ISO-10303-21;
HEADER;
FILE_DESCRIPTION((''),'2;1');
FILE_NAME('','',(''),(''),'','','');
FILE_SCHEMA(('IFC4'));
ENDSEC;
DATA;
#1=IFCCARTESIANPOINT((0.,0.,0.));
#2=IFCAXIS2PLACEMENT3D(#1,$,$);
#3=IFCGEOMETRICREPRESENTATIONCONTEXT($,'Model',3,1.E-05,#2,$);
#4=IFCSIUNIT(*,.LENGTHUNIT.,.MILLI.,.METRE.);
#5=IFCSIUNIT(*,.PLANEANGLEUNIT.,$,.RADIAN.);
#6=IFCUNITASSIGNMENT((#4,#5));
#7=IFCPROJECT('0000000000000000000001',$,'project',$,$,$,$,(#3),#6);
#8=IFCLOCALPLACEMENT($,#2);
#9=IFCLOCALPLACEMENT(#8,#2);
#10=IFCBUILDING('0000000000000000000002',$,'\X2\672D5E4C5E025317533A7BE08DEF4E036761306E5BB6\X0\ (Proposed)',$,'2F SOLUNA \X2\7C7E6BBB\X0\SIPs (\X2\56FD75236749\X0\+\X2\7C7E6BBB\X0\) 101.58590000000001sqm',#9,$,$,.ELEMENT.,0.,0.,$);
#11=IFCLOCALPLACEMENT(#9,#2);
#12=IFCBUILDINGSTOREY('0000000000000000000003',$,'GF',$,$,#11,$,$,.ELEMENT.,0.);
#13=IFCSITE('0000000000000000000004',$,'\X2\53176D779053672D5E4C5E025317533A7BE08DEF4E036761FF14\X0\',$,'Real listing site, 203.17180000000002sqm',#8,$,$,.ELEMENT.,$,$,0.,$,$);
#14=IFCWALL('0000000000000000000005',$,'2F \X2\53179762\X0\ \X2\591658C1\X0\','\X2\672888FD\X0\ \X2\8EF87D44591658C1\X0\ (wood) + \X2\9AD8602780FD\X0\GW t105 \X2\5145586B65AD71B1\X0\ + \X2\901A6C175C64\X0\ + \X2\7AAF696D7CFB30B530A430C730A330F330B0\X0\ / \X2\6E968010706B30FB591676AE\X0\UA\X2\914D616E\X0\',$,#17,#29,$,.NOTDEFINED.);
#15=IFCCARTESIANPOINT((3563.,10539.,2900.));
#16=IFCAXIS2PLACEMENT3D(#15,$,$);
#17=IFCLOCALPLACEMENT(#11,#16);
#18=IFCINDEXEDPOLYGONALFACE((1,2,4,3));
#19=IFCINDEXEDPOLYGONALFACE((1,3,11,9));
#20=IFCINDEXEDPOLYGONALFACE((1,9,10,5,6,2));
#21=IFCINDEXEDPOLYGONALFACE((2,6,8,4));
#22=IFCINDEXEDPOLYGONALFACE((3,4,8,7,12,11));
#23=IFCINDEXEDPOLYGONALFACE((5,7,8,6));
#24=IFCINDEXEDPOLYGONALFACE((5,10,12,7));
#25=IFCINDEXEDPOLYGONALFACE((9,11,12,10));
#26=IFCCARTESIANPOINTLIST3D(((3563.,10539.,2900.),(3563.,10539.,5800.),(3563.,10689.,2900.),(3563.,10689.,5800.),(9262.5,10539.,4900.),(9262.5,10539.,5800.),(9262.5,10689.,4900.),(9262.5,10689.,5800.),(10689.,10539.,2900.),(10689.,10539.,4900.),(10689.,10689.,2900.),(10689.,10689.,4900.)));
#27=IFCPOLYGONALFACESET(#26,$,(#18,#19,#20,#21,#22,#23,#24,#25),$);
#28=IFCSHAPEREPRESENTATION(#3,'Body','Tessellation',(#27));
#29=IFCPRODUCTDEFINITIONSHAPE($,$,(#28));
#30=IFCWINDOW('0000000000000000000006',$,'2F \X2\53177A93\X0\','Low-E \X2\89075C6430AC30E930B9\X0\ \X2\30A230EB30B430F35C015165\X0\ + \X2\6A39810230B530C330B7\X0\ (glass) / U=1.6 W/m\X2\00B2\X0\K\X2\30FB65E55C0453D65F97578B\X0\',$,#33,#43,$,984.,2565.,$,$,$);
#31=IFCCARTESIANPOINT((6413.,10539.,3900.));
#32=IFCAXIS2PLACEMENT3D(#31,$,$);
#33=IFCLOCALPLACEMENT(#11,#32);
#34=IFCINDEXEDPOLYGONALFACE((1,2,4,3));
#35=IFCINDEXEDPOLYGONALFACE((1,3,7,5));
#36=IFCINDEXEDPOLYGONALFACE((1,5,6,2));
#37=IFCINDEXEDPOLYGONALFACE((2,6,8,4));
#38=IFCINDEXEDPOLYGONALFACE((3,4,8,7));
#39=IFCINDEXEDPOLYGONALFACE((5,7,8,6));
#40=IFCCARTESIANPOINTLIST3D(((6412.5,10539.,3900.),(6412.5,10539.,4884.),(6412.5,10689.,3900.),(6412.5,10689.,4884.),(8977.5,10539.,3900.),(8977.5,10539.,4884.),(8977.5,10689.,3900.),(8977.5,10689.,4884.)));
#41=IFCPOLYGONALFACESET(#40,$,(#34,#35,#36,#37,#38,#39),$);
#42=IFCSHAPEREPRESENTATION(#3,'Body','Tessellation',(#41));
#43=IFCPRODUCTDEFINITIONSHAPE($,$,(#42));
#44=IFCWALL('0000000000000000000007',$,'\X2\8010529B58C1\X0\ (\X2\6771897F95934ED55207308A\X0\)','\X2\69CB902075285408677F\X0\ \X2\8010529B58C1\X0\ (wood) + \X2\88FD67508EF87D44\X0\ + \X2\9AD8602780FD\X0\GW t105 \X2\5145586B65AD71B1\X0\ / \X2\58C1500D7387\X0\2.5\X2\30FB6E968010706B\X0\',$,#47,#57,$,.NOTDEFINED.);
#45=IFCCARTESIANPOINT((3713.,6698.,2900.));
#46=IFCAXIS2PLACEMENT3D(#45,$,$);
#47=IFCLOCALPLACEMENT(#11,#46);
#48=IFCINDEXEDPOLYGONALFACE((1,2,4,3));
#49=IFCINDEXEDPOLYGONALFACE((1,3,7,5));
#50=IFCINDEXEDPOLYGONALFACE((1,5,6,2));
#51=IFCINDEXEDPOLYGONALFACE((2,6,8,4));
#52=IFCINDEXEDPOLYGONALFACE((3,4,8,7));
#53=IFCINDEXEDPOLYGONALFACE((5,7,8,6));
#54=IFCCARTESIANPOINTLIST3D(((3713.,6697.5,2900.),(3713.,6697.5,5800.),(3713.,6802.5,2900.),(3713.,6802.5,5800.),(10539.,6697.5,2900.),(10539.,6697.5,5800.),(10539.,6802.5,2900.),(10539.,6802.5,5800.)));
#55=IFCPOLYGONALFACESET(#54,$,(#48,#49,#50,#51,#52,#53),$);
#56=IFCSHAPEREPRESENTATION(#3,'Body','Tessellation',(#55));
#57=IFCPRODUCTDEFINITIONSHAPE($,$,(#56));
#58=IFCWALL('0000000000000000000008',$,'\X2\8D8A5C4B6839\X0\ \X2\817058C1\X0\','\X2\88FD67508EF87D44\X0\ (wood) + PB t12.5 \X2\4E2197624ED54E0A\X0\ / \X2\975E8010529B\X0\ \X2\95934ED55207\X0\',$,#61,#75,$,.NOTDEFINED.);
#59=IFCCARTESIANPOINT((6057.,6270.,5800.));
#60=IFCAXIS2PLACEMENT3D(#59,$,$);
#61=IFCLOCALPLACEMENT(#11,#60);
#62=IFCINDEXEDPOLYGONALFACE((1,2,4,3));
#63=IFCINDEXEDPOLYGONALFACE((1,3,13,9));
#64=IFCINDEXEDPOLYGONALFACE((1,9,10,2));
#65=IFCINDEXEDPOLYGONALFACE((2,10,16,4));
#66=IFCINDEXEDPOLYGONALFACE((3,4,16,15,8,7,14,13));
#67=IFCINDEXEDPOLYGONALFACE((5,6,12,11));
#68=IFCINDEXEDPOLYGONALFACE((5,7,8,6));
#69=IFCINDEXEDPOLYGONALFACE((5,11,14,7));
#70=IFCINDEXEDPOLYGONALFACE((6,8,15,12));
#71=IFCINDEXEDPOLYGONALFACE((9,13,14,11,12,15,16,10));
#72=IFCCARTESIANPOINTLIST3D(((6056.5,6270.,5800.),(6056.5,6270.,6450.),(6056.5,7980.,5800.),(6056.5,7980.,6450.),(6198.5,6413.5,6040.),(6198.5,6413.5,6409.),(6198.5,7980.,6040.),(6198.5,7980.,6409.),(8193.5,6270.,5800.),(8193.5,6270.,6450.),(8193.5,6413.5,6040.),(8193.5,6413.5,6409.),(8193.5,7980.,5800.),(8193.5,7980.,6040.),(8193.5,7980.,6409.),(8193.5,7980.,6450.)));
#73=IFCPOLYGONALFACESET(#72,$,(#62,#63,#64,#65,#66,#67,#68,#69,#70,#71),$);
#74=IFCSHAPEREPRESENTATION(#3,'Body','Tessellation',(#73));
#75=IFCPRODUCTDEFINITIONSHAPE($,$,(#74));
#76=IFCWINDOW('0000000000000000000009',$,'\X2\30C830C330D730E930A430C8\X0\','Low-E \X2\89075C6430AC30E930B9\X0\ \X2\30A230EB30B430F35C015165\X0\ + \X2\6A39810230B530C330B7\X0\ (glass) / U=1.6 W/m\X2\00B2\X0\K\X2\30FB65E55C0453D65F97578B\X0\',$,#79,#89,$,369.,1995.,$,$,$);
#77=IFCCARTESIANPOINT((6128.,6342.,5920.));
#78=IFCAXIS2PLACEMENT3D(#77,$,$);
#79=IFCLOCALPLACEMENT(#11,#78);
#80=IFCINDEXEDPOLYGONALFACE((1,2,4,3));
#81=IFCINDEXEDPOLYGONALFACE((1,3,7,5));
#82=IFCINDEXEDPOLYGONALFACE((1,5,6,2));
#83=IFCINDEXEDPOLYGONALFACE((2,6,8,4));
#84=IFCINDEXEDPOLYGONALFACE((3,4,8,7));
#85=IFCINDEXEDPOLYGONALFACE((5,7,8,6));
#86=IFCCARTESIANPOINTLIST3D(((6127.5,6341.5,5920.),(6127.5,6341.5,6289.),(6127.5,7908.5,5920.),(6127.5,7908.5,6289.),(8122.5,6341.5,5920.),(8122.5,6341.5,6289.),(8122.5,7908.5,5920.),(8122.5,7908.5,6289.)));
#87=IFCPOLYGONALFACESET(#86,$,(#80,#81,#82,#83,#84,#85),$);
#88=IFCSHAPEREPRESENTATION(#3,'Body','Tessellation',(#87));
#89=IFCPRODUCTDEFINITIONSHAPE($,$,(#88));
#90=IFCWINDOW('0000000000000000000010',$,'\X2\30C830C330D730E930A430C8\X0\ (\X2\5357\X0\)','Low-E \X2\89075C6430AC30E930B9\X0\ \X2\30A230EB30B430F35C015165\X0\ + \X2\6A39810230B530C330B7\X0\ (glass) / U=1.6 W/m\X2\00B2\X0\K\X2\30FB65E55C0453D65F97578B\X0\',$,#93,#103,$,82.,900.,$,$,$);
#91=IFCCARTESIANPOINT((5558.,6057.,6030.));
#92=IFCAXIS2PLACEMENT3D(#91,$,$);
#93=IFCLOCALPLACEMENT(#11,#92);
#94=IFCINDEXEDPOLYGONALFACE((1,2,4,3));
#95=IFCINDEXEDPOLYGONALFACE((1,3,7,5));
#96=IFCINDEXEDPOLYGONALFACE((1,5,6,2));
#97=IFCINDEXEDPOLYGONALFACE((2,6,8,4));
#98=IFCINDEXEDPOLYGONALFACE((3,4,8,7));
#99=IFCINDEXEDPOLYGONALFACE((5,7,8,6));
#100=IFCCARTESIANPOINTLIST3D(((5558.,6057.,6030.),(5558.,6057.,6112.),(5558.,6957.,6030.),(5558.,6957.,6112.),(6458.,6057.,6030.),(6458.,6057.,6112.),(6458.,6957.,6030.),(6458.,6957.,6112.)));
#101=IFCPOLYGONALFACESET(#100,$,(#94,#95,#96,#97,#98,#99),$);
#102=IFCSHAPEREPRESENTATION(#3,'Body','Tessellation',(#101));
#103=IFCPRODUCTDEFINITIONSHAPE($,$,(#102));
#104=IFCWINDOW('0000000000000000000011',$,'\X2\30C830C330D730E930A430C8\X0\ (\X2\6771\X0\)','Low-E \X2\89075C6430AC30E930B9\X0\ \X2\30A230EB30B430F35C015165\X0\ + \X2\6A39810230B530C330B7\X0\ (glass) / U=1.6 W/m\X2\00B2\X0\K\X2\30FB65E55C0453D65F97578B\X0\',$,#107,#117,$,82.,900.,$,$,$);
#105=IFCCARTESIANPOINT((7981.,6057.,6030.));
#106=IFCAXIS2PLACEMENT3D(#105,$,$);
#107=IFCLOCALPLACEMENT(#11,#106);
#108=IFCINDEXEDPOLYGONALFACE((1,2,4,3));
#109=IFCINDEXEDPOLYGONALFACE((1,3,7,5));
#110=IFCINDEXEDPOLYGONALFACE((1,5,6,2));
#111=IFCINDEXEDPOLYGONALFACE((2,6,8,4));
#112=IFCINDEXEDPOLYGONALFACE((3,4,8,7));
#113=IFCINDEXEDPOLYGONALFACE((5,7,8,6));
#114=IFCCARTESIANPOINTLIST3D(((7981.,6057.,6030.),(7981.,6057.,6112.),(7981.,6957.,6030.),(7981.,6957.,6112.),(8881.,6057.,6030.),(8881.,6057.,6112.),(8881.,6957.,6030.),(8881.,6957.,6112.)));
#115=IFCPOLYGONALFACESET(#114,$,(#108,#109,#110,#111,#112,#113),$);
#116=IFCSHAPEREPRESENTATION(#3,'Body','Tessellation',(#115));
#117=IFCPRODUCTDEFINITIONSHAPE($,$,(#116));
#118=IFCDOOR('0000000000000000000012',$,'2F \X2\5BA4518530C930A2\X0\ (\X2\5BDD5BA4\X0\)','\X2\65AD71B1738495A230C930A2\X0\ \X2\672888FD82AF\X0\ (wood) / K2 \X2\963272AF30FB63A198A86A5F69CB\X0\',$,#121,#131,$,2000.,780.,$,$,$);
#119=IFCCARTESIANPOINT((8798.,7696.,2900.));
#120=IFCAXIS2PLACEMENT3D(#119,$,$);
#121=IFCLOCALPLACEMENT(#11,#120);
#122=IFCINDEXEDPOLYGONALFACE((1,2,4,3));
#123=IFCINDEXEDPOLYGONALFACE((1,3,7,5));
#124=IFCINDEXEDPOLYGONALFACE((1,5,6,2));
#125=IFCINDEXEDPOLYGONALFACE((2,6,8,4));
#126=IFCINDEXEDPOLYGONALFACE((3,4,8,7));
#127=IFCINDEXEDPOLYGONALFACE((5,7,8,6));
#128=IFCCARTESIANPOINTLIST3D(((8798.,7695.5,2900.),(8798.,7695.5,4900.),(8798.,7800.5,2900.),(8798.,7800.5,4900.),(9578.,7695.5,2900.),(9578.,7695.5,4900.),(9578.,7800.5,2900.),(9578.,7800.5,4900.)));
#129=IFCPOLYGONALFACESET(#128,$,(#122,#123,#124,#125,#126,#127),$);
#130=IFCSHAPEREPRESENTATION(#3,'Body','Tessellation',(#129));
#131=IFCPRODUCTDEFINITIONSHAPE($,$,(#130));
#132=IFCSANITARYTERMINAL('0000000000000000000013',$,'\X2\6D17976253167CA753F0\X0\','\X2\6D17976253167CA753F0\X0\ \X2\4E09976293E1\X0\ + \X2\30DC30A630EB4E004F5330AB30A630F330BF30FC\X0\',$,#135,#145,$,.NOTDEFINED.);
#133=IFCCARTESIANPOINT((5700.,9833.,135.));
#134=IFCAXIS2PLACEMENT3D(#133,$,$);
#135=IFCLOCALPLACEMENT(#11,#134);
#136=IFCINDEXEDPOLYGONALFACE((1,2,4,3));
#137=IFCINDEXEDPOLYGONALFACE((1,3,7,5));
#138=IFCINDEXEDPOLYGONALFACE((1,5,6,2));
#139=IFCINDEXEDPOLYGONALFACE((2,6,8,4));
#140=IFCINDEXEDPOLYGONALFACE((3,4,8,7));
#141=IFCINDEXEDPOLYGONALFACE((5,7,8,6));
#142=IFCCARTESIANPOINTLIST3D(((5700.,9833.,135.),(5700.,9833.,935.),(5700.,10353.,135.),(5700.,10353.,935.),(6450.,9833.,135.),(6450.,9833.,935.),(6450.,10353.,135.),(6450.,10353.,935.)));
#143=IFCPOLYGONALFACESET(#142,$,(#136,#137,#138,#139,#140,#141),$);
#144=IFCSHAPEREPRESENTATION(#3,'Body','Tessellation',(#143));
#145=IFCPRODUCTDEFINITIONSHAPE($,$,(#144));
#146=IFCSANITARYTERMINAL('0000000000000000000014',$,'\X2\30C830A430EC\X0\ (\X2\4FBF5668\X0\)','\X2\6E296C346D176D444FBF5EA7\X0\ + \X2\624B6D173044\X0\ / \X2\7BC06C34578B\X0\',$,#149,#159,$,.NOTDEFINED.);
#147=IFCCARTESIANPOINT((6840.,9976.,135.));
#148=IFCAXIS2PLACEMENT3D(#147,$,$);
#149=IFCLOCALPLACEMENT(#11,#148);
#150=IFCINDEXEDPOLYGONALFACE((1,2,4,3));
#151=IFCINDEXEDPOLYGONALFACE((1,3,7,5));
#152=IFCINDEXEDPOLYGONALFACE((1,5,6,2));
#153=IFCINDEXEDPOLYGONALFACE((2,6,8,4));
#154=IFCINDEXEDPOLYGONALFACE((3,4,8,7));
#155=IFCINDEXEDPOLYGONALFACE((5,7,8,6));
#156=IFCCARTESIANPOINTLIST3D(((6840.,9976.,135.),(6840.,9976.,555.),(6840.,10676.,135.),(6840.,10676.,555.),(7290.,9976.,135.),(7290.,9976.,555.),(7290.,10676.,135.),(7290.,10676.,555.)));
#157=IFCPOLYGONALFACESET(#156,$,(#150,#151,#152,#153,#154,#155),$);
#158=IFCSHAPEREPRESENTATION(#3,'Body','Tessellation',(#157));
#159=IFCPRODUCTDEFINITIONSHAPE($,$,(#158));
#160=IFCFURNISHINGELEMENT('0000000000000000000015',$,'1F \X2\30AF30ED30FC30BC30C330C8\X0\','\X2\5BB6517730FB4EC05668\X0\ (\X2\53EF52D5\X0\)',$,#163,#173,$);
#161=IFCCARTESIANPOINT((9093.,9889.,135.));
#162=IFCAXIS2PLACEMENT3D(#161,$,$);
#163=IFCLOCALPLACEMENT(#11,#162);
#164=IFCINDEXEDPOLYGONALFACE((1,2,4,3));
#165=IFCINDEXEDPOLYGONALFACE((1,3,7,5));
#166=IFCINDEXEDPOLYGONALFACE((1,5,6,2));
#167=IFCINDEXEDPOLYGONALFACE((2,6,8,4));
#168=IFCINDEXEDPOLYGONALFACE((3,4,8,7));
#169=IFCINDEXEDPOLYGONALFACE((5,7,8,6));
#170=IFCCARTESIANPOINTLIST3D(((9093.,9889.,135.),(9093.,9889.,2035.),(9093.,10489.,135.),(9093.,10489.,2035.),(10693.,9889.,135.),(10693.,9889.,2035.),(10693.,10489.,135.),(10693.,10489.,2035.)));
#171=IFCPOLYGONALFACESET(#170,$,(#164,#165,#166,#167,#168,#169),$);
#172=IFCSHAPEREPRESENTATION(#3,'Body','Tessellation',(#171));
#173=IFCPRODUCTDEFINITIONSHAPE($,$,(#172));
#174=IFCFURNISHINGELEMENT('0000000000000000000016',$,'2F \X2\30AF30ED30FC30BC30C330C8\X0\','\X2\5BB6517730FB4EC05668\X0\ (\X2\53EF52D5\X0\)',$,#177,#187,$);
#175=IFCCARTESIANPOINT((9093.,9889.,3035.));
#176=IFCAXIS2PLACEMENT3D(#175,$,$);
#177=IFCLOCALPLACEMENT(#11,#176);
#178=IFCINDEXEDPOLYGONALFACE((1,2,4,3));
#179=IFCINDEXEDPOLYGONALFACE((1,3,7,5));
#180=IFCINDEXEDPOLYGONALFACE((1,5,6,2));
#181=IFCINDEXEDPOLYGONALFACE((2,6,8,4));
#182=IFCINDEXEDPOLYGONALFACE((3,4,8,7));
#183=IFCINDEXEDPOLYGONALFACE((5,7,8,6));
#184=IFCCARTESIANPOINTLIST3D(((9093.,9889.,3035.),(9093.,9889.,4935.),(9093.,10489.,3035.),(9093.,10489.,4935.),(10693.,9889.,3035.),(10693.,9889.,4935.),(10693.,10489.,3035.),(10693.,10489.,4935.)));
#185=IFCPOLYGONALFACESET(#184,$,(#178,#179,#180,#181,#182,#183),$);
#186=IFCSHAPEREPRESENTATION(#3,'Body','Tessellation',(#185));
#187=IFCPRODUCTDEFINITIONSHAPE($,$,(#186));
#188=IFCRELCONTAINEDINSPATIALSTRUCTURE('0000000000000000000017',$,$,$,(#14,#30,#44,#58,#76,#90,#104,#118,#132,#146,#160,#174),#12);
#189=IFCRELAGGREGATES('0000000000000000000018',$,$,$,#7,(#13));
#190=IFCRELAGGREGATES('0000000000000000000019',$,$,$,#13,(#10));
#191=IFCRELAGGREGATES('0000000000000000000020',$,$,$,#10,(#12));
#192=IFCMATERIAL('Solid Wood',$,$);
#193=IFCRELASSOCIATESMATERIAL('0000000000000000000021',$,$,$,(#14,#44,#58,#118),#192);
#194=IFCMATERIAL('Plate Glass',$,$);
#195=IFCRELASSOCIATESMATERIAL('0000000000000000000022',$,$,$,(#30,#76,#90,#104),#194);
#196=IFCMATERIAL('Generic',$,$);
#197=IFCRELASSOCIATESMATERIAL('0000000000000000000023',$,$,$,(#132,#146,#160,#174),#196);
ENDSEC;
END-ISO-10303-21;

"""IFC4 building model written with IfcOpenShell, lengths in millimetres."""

from ifc_helpers import new_model, si_unit, frame, frame_2d, origin, place, context, project, spatial, rectangle, extrude, material, element, fill, save


model = new_model("IFC4")

# Units and contexts
model_context = context("Model", 3, precision=1e-05, world=origin())
ifc_project = project(units=[si_unit("LENGTHUNIT", "METRE", prefix="MILLI"), si_unit("PLANEANGLEUNIT", "RADIAN")], contexts=[model_context])

# Site, building, storey
site_placement = place(None, origin())
site = spatial("IfcSite", under=ifc_project, at=site_placement, Name="北海道札幌市北区篠路七条４", ObjectType="Real listing site, 203.17180000000002sqm", CompositionType="ELEMENT", RefElevation=0.0)
building_placement = place(site_placement, origin())
building = spatial("IfcBuilding", under=site, at=building_placement, Name="札幌市北区篠路七条の家 (Proposed)", ObjectType="2F SOLUNA 籾殻SIPs (国産杉+籾殻) 101.58590000000001sqm", CompositionType="ELEMENT", ElevationOfRefHeight=0.0, ElevationOfTerrain=0.0)
storey_placement = place(building_placement, origin())
storey = spatial("IfcBuildingStorey", under=building, at=storey_placement, Name="GF", CompositionType="ELEMENT", Elevation=0.0)

# Wall, opening, window
ifc_material_1 = material(Name="Solid Wood")
wall_1_placement = place(storey_placement, frame((3563.0, 10539.0, 2900.0)))
wall_1 = element("IfcWall", 1, at=wall_1_placement, inside=storey, material=ifc_material_1, Name="2F 北面 外壁", Description="木製 軸組外壁 (wood) + 高性能GW t105 充填断熱 + 通気層 + 窯業系サイディング / 準耐火・外皮UA配慮", PredefinedType="NOTDEFINED", context=model_context, shape_type="SweptSolid", body=[
    extrude(rectangle(XDim=7126.0, YDim=150.0, at=frame_2d((3563.0, 75.0))), frame((3563.0, 10539.0, 2900.0)), (0.0, 0.0, 1.0), 2900.0),
])
opening_1_placement = place(storey_placement, frame((6413.0, 10539.0, 3900.0)))
opening_1 = element("IfcOpeningElement", 2, at=opening_1_placement, cuts=wall_1, PredefinedType="NOTDEFINED", context=model_context, shape_type="SweptSolid", body=[
    extrude(rectangle(XDim=2565.0, YDim=150.0, at=frame_2d((1282.0, 75.0))), frame((6413.0, 10539.0, 3900.0)), (0.0, 0.0, 1.0), 984.0),
])
ifc_material_2 = material(Name="Plate Glass")
window_1_placement = place(storey_placement, frame((6413.0, 10539.0, 3900.0)))
window_1 = element("IfcWindow", 3, at=window_1_placement, inside=storey, material=ifc_material_2, Name="2F 北窓", Description="Low-E 複層ガラス アルゴン封入 + 樹脂サッシ (glass) / U=1.6 W/m²K・日射取得型", OverallHeight=984.0, OverallWidth=2565.0, context=model_context, shape_type="SweptSolid", body=[
    extrude(rectangle(XDim=2565.0, YDim=150.0, at=frame_2d((1282.0, 75.0))), frame((6413.0, 10539.0, 3900.0)), (0.0, 0.0, 1.0), 984.0),
])
fill(opening_1, window_1)

# Wall
wall_2_placement = place(storey_placement, frame((3713.0, 6698.0, 2900.0)))
element("IfcWall", 4, at=wall_2_placement, inside=storey, material=ifc_material_1, Name="耐力壁 (東西間仕切り)", Description="構造用合板 耐力壁 (wood) + 製材軸組 + 高性能GW t105 充填断熱 / 壁倍率2.5・準耐火", PredefinedType="NOTDEFINED", context=model_context, shape_type="SweptSolid", body=[
    extrude(rectangle(XDim=6826.0, YDim=105.0, at=frame_2d((3413.0, 52.0))), frame((3713.0, 6698.0, 2900.0)), (0.0, 0.0, 1.0), 2900.0),
])

# Wall, openings, windows
wall_3_placement = place(storey_placement, frame((6057.0, 6270.0, 5800.0)))
wall_3 = element("IfcWall", 5, at=wall_3_placement, inside=storey, material=ifc_material_1, Name="越屋根 腰壁", Description="製材軸組 (wood) + PB t12.5 両面仕上 / 非耐力 間仕切", PredefinedType="NOTDEFINED", context=model_context, shape_type="SweptSolid", body=[
    extrude(rectangle(XDim=2137.0, YDim=1710.0, at=frame_2d((1068.0, 855.0))), frame((6057.0, 6270.0, 5800.0)), (0.0, 0.0, 1.0), 650.0),
])
opening_2_placement = place(storey_placement, frame((6128.0, 6342.0, 5920.0)))
opening_2 = element("IfcOpeningElement", 6, at=opening_2_placement, cuts=wall_3, PredefinedType="NOTDEFINED", context=model_context, shape_type="SweptSolid", body=[
    extrude(rectangle(XDim=1995.0, YDim=1567.0, at=frame_2d((997.0, 783.0))), frame((6128.0, 6342.0, 5920.0)), (0.0, 0.0, 1.0), 369.0),
])
opening_3_placement = place(storey_placement, frame((5558.0, 6057.0, 6030.0)))
opening_3 = element("IfcOpeningElement", 7, at=opening_3_placement, cuts=wall_3, PredefinedType="NOTDEFINED", context=model_context, shape_type="SweptSolid", body=[
    extrude(rectangle(XDim=900.0, YDim=900.0, at=frame_2d((450.0, 450.0))), frame((5558.0, 6057.0, 6030.0)), (0.0, 0.0, 1.0), 82.0),
])
opening_4_placement = place(storey_placement, frame((7981.0, 6057.0, 6030.0)))
opening_4 = element("IfcOpeningElement", 8, at=opening_4_placement, cuts=wall_3, PredefinedType="NOTDEFINED", context=model_context, shape_type="SweptSolid", body=[
    extrude(rectangle(XDim=900.0, YDim=900.0, at=frame_2d((450.0, 450.0))), frame((7981.0, 6057.0, 6030.0)), (0.0, 0.0, 1.0), 82.0),
])
window_2_placement = place(storey_placement, frame((6128.0, 6342.0, 5920.0)))
window_2 = element("IfcWindow", 9, at=window_2_placement, inside=storey, material=ifc_material_2, Name="トップライト", Description="Low-E 複層ガラス アルゴン封入 + 樹脂サッシ (glass) / U=1.6 W/m²K・日射取得型", OverallHeight=369.0, OverallWidth=1995.0, context=model_context, shape_type="SweptSolid", body=[
    extrude(rectangle(XDim=1995.0, YDim=1567.0, at=frame_2d((997.0, 783.0))), frame((6128.0, 6342.0, 5920.0)), (0.0, 0.0, 1.0), 369.0),
])
fill(opening_2, window_2)
window_3_placement = place(storey_placement, frame((5558.0, 6057.0, 6030.0)))
window_3 = element("IfcWindow", 10, at=window_3_placement, inside=storey, material=ifc_material_2, Name="トップライト (南)", Description="Low-E 複層ガラス アルゴン封入 + 樹脂サッシ (glass) / U=1.6 W/m²K・日射取得型", OverallHeight=82.0, OverallWidth=900.0, context=model_context, shape_type="SweptSolid", body=[
    extrude(rectangle(XDim=900.0, YDim=900.0, at=frame_2d((450.0, 450.0))), frame((5558.0, 6057.0, 6030.0)), (0.0, 0.0, 1.0), 82.0),
])
fill(opening_3, window_3)
window_4_placement = place(storey_placement, frame((7981.0, 6057.0, 6030.0)))
window_4 = element("IfcWindow", 11, at=window_4_placement, inside=storey, material=ifc_material_2, Name="トップライト (東)", Description="Low-E 複層ガラス アルゴン封入 + 樹脂サッシ (glass) / U=1.6 W/m²K・日射取得型", OverallHeight=82.0, OverallWidth=900.0, context=model_context, shape_type="SweptSolid", body=[
    extrude(rectangle(XDim=900.0, YDim=900.0, at=frame_2d((450.0, 450.0))), frame((7981.0, 6057.0, 6030.0)), (0.0, 0.0, 1.0), 82.0),
])
fill(opening_4, window_4)

# Door
door_placement = place(storey_placement, frame((8798.0, 7696.0, 2900.0)))
element("IfcDoor", 12, at=door_placement, inside=storey, material=ifc_material_1, Name="2F 室内ドア (寝室)", Description="断熱玄関ドア 木製芯 (wood) / K2 防犯・採風機構", OverallHeight=2000.0, OverallWidth=780.0, context=model_context, shape_type="SweptSolid", body=[
    extrude(rectangle(XDim=780.0, YDim=105.0, at=frame_2d((390.0, 52.0))), frame((8798.0, 7696.0, 2900.0)), (0.0, 0.0, 1.0), 2000.0),
])

# Sanitary terminals
ifc_material_3 = material(Name="Generic")
sanitary_terminal_1_placement = place(storey_placement, frame((5700.0, 9833.0, 135.0)))
element("IfcSanitaryTerminal", 13, at=sanitary_terminal_1_placement, inside=storey, material=ifc_material_3, Name="洗面化粧台", Description="洗面化粧台 三面鏡 + ボウル一体カウンター", PredefinedType="NOTDEFINED", context=model_context, shape_type="SweptSolid", body=[
    extrude(rectangle(XDim=750.0, YDim=520.0, at=frame_2d((375.0, 260.0))), frame((5700.0, 9833.0, 135.0)), (0.0, 0.0, 1.0), 800.0),
])
sanitary_terminal_2_placement = place(storey_placement, frame((6840.0, 9976.0, 135.0)))
element("IfcSanitaryTerminal", 14, at=sanitary_terminal_2_placement, inside=storey, material=ifc_material_3, Name="トイレ (便器)", Description="温水洗浄便座 + 手洗い / 節水型", PredefinedType="NOTDEFINED", context=model_context, shape_type="SweptSolid", body=[
    extrude(rectangle(XDim=450.0, YDim=700.0, at=frame_2d((225.0, 350.0))), frame((6840.0, 9976.0, 135.0)), (0.0, 0.0, 1.0), 420.0),
])

# Furnishing elements
furnishing_1_placement = place(storey_placement, frame((9093.0, 9889.0, 135.0)))
element("IfcFurnishingElement", 15, at=furnishing_1_placement, inside=storey, material=ifc_material_3, Name="1F クローゼット", Description="家具・什器 (可動)", context=model_context, shape_type="SweptSolid", body=[
    extrude(rectangle(XDim=1600.0, YDim=600.0, at=frame_2d((800.0, 300.0))), frame((9093.0, 9889.0, 135.0)), (0.0, 0.0, 1.0), 1900.0),
])
furnishing_2_placement = place(storey_placement, frame((9093.0, 9889.0, 3035.0)))
element("IfcFurnishingElement", 16, at=furnishing_2_placement, inside=storey, material=ifc_material_3, Name="2F クローゼット", Description="家具・什器 (可動)", context=model_context, shape_type="SweptSolid", body=[
    extrude(rectangle(XDim=1600.0, YDim=600.0, at=frame_2d((800.0, 300.0))), frame((9093.0, 9889.0, 3035.0)), (0.0, 0.0, 1.0), 1900.0),
])

save(model, "model.ifc")
